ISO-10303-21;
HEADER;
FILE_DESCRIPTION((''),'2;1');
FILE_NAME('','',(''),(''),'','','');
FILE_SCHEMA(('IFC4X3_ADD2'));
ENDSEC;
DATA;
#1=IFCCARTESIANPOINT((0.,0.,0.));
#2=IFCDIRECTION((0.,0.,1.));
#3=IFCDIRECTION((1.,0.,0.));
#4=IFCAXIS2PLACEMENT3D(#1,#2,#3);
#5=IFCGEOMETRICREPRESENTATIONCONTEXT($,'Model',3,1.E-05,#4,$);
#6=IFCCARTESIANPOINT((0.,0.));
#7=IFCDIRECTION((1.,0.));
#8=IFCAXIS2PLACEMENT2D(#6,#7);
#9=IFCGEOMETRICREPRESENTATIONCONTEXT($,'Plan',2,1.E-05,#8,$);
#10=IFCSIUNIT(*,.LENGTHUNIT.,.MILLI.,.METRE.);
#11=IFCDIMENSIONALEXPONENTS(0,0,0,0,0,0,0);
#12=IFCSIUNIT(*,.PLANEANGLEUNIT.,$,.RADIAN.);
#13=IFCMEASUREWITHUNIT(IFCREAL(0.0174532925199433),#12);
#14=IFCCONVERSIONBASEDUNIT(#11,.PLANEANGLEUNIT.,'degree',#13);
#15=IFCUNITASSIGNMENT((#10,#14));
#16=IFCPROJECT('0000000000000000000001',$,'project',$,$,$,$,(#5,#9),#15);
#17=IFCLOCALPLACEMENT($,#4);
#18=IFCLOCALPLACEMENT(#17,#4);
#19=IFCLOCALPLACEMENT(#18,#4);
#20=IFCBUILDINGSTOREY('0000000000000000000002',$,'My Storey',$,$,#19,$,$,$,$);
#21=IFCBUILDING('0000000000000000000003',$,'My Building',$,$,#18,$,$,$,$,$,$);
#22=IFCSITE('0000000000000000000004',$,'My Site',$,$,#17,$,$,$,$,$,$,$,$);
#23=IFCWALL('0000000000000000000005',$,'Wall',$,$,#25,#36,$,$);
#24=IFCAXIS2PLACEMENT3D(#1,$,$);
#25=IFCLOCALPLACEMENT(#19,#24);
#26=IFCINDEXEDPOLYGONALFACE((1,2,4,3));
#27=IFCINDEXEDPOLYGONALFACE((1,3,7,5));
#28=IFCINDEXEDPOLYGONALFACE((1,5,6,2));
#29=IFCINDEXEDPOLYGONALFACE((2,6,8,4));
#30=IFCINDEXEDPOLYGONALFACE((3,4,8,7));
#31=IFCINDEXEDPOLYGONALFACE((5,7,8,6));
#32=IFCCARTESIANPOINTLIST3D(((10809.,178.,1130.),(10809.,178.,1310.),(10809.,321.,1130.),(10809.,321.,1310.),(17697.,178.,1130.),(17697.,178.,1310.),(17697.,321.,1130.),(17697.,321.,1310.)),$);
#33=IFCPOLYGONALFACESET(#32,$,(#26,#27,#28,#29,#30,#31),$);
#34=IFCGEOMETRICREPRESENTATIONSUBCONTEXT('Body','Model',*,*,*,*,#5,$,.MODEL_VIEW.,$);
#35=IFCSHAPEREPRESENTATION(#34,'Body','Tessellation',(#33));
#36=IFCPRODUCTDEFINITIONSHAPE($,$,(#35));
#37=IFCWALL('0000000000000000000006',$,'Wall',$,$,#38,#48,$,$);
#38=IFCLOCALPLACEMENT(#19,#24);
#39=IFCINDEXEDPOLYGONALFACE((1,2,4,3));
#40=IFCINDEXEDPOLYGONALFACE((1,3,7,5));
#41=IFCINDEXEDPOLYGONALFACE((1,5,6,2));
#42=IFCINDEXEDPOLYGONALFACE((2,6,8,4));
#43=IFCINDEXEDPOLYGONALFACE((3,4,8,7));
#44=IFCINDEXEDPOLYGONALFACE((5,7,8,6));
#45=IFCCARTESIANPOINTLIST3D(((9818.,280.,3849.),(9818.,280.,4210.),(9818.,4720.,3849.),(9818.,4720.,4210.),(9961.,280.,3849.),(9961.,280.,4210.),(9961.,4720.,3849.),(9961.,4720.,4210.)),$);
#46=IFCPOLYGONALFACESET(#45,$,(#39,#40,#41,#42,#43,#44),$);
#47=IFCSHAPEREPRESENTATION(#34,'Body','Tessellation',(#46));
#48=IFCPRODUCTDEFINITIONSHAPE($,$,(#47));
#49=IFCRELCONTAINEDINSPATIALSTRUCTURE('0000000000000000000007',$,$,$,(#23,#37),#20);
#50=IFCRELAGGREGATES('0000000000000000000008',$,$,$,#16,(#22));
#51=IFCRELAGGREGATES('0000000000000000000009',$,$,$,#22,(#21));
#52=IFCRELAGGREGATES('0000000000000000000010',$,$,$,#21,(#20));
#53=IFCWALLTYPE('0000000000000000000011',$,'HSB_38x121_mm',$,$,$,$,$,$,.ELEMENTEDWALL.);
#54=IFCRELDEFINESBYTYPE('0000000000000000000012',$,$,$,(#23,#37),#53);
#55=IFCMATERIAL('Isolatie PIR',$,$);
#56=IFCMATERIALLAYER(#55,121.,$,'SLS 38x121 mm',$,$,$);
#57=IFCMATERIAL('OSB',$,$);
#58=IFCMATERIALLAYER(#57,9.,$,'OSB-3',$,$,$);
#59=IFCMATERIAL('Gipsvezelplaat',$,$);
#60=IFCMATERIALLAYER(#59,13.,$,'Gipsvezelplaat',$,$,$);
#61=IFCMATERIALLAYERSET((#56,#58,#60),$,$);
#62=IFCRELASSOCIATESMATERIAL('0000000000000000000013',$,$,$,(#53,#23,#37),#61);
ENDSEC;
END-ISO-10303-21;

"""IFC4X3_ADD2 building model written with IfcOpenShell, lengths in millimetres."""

from ifc_helpers import new_model, entity, si_unit, converted_unit, frame, origin_with_axes, origin_2d_with_axis, place, context, subcontext, project, spatial, indexed_curve, outline, extrude, material, layer, layer_set, layer_usage, type_object, element, save


model = new_model("IFC4X3_ADD2")

# Units and contexts
model_context = context("Model", 3, precision=1e-05, world=origin_with_axes())
plan_context = context("Plan", 2, precision=1e-05, world=origin_2d_with_axis())
body_context_1 = subcontext(model_context, "Body", "Model", "MODEL_VIEW")
ifc_project = project(units=[si_unit("LENGTHUNIT", "METRE", prefix="MILLI"), converted_unit("PLANEANGLEUNIT", "degree", entity("IfcReal", 0.0174532925199433), si_unit("PLANEANGLEUNIT", "RADIAN"), dimensions=[0, 0, 0, 0, 0, 0, 0])], contexts=[model_context, plan_context])

# Site, building, storey
site_placement = place(None, origin_with_axes())
site = spatial("IfcSite", under=ifc_project, at=site_placement, Name="My Site")
building_placement = place(site_placement, origin_with_axes())
building = spatial("IfcBuilding", under=site, at=building_placement, Name="My Building")
storey_placement = place(building_placement, origin_with_axes())
storey = spatial("IfcBuildingStorey", under=building, at=storey_placement, Name="My Storey")

# Walls
ifc_material_1 = material(Name="Isolatie PIR")
ifc_layer_1 = layer(ifc_material_1, 121.0, Name="SLS 38x121 mm")
ifc_material_2 = material(Name="OSB")
ifc_layer_2 = layer(ifc_material_2, 9.0, Name="OSB-3")
ifc_material_3 = material(Name="Gipsvezelplaat")
ifc_layer_3 = layer(ifc_material_3, 13.0, Name="Gipsvezelplaat")
ifc_layer_set_1 = layer_set([ifc_layer_1, ifc_layer_2, ifc_layer_3])
wall_type_1 = type_object("IfcWallType", Name="HSB_38x121_mm", PredefinedType="ELEMENTEDWALL", material=ifc_layer_set_1)
ifc_layer_usage_1 = layer_usage(ifc_layer_set_1, "AXIS2", "POSITIVE", 0.0)
wall_1_placement = place(storey_placement, frame((10809.0, 178.0, 1130.0), z_axis=(0.0, 0.0, 1.0), x_axis=(1.0, 0.0, 0.0)))
element("IfcWall", 1, at=wall_1_placement, inside=storey, type_object=wall_type_1, material=ifc_layer_usage_1, Name="Wall", context=body_context_1, shape_type="SweptSolid", body=[
    extrude(outline(indexed_curve([(0.0, 0.0), (0.0, 143.0), (6888.0, 143.0), (6888.0, 0.0), (0.0, 0.0)], self_intersect=False)), origin_with_axes(), (0.0, 0.0, 1.0), 180.0),
])
ifc_layer_usage_2 = layer_usage(ifc_layer_set_1, "AXIS2", "POSITIVE", 0.0)
wall_2_placement = place(storey_placement, frame((9961.0, 280.0, 3849.0), z_axis=(0.0, 0.0, 1.0), x_axis=(0.0, 1.0, 0.0)))
element("IfcWall", 2, at=wall_2_placement, inside=storey, type_object=wall_type_1, material=ifc_layer_usage_2, Name="Wall", context=body_context_1, shape_type="SweptSolid", body=[
    extrude(outline(indexed_curve([(0.0, 0.0), (0.0, 143.0), (4440.0, 143.0), (4440.0, 0.0), (0.0, 0.0)], self_intersect=False)), origin_with_axes(), (0.0, 0.0, 1.0), 361.0),
])

save(model, "model.ifc")
